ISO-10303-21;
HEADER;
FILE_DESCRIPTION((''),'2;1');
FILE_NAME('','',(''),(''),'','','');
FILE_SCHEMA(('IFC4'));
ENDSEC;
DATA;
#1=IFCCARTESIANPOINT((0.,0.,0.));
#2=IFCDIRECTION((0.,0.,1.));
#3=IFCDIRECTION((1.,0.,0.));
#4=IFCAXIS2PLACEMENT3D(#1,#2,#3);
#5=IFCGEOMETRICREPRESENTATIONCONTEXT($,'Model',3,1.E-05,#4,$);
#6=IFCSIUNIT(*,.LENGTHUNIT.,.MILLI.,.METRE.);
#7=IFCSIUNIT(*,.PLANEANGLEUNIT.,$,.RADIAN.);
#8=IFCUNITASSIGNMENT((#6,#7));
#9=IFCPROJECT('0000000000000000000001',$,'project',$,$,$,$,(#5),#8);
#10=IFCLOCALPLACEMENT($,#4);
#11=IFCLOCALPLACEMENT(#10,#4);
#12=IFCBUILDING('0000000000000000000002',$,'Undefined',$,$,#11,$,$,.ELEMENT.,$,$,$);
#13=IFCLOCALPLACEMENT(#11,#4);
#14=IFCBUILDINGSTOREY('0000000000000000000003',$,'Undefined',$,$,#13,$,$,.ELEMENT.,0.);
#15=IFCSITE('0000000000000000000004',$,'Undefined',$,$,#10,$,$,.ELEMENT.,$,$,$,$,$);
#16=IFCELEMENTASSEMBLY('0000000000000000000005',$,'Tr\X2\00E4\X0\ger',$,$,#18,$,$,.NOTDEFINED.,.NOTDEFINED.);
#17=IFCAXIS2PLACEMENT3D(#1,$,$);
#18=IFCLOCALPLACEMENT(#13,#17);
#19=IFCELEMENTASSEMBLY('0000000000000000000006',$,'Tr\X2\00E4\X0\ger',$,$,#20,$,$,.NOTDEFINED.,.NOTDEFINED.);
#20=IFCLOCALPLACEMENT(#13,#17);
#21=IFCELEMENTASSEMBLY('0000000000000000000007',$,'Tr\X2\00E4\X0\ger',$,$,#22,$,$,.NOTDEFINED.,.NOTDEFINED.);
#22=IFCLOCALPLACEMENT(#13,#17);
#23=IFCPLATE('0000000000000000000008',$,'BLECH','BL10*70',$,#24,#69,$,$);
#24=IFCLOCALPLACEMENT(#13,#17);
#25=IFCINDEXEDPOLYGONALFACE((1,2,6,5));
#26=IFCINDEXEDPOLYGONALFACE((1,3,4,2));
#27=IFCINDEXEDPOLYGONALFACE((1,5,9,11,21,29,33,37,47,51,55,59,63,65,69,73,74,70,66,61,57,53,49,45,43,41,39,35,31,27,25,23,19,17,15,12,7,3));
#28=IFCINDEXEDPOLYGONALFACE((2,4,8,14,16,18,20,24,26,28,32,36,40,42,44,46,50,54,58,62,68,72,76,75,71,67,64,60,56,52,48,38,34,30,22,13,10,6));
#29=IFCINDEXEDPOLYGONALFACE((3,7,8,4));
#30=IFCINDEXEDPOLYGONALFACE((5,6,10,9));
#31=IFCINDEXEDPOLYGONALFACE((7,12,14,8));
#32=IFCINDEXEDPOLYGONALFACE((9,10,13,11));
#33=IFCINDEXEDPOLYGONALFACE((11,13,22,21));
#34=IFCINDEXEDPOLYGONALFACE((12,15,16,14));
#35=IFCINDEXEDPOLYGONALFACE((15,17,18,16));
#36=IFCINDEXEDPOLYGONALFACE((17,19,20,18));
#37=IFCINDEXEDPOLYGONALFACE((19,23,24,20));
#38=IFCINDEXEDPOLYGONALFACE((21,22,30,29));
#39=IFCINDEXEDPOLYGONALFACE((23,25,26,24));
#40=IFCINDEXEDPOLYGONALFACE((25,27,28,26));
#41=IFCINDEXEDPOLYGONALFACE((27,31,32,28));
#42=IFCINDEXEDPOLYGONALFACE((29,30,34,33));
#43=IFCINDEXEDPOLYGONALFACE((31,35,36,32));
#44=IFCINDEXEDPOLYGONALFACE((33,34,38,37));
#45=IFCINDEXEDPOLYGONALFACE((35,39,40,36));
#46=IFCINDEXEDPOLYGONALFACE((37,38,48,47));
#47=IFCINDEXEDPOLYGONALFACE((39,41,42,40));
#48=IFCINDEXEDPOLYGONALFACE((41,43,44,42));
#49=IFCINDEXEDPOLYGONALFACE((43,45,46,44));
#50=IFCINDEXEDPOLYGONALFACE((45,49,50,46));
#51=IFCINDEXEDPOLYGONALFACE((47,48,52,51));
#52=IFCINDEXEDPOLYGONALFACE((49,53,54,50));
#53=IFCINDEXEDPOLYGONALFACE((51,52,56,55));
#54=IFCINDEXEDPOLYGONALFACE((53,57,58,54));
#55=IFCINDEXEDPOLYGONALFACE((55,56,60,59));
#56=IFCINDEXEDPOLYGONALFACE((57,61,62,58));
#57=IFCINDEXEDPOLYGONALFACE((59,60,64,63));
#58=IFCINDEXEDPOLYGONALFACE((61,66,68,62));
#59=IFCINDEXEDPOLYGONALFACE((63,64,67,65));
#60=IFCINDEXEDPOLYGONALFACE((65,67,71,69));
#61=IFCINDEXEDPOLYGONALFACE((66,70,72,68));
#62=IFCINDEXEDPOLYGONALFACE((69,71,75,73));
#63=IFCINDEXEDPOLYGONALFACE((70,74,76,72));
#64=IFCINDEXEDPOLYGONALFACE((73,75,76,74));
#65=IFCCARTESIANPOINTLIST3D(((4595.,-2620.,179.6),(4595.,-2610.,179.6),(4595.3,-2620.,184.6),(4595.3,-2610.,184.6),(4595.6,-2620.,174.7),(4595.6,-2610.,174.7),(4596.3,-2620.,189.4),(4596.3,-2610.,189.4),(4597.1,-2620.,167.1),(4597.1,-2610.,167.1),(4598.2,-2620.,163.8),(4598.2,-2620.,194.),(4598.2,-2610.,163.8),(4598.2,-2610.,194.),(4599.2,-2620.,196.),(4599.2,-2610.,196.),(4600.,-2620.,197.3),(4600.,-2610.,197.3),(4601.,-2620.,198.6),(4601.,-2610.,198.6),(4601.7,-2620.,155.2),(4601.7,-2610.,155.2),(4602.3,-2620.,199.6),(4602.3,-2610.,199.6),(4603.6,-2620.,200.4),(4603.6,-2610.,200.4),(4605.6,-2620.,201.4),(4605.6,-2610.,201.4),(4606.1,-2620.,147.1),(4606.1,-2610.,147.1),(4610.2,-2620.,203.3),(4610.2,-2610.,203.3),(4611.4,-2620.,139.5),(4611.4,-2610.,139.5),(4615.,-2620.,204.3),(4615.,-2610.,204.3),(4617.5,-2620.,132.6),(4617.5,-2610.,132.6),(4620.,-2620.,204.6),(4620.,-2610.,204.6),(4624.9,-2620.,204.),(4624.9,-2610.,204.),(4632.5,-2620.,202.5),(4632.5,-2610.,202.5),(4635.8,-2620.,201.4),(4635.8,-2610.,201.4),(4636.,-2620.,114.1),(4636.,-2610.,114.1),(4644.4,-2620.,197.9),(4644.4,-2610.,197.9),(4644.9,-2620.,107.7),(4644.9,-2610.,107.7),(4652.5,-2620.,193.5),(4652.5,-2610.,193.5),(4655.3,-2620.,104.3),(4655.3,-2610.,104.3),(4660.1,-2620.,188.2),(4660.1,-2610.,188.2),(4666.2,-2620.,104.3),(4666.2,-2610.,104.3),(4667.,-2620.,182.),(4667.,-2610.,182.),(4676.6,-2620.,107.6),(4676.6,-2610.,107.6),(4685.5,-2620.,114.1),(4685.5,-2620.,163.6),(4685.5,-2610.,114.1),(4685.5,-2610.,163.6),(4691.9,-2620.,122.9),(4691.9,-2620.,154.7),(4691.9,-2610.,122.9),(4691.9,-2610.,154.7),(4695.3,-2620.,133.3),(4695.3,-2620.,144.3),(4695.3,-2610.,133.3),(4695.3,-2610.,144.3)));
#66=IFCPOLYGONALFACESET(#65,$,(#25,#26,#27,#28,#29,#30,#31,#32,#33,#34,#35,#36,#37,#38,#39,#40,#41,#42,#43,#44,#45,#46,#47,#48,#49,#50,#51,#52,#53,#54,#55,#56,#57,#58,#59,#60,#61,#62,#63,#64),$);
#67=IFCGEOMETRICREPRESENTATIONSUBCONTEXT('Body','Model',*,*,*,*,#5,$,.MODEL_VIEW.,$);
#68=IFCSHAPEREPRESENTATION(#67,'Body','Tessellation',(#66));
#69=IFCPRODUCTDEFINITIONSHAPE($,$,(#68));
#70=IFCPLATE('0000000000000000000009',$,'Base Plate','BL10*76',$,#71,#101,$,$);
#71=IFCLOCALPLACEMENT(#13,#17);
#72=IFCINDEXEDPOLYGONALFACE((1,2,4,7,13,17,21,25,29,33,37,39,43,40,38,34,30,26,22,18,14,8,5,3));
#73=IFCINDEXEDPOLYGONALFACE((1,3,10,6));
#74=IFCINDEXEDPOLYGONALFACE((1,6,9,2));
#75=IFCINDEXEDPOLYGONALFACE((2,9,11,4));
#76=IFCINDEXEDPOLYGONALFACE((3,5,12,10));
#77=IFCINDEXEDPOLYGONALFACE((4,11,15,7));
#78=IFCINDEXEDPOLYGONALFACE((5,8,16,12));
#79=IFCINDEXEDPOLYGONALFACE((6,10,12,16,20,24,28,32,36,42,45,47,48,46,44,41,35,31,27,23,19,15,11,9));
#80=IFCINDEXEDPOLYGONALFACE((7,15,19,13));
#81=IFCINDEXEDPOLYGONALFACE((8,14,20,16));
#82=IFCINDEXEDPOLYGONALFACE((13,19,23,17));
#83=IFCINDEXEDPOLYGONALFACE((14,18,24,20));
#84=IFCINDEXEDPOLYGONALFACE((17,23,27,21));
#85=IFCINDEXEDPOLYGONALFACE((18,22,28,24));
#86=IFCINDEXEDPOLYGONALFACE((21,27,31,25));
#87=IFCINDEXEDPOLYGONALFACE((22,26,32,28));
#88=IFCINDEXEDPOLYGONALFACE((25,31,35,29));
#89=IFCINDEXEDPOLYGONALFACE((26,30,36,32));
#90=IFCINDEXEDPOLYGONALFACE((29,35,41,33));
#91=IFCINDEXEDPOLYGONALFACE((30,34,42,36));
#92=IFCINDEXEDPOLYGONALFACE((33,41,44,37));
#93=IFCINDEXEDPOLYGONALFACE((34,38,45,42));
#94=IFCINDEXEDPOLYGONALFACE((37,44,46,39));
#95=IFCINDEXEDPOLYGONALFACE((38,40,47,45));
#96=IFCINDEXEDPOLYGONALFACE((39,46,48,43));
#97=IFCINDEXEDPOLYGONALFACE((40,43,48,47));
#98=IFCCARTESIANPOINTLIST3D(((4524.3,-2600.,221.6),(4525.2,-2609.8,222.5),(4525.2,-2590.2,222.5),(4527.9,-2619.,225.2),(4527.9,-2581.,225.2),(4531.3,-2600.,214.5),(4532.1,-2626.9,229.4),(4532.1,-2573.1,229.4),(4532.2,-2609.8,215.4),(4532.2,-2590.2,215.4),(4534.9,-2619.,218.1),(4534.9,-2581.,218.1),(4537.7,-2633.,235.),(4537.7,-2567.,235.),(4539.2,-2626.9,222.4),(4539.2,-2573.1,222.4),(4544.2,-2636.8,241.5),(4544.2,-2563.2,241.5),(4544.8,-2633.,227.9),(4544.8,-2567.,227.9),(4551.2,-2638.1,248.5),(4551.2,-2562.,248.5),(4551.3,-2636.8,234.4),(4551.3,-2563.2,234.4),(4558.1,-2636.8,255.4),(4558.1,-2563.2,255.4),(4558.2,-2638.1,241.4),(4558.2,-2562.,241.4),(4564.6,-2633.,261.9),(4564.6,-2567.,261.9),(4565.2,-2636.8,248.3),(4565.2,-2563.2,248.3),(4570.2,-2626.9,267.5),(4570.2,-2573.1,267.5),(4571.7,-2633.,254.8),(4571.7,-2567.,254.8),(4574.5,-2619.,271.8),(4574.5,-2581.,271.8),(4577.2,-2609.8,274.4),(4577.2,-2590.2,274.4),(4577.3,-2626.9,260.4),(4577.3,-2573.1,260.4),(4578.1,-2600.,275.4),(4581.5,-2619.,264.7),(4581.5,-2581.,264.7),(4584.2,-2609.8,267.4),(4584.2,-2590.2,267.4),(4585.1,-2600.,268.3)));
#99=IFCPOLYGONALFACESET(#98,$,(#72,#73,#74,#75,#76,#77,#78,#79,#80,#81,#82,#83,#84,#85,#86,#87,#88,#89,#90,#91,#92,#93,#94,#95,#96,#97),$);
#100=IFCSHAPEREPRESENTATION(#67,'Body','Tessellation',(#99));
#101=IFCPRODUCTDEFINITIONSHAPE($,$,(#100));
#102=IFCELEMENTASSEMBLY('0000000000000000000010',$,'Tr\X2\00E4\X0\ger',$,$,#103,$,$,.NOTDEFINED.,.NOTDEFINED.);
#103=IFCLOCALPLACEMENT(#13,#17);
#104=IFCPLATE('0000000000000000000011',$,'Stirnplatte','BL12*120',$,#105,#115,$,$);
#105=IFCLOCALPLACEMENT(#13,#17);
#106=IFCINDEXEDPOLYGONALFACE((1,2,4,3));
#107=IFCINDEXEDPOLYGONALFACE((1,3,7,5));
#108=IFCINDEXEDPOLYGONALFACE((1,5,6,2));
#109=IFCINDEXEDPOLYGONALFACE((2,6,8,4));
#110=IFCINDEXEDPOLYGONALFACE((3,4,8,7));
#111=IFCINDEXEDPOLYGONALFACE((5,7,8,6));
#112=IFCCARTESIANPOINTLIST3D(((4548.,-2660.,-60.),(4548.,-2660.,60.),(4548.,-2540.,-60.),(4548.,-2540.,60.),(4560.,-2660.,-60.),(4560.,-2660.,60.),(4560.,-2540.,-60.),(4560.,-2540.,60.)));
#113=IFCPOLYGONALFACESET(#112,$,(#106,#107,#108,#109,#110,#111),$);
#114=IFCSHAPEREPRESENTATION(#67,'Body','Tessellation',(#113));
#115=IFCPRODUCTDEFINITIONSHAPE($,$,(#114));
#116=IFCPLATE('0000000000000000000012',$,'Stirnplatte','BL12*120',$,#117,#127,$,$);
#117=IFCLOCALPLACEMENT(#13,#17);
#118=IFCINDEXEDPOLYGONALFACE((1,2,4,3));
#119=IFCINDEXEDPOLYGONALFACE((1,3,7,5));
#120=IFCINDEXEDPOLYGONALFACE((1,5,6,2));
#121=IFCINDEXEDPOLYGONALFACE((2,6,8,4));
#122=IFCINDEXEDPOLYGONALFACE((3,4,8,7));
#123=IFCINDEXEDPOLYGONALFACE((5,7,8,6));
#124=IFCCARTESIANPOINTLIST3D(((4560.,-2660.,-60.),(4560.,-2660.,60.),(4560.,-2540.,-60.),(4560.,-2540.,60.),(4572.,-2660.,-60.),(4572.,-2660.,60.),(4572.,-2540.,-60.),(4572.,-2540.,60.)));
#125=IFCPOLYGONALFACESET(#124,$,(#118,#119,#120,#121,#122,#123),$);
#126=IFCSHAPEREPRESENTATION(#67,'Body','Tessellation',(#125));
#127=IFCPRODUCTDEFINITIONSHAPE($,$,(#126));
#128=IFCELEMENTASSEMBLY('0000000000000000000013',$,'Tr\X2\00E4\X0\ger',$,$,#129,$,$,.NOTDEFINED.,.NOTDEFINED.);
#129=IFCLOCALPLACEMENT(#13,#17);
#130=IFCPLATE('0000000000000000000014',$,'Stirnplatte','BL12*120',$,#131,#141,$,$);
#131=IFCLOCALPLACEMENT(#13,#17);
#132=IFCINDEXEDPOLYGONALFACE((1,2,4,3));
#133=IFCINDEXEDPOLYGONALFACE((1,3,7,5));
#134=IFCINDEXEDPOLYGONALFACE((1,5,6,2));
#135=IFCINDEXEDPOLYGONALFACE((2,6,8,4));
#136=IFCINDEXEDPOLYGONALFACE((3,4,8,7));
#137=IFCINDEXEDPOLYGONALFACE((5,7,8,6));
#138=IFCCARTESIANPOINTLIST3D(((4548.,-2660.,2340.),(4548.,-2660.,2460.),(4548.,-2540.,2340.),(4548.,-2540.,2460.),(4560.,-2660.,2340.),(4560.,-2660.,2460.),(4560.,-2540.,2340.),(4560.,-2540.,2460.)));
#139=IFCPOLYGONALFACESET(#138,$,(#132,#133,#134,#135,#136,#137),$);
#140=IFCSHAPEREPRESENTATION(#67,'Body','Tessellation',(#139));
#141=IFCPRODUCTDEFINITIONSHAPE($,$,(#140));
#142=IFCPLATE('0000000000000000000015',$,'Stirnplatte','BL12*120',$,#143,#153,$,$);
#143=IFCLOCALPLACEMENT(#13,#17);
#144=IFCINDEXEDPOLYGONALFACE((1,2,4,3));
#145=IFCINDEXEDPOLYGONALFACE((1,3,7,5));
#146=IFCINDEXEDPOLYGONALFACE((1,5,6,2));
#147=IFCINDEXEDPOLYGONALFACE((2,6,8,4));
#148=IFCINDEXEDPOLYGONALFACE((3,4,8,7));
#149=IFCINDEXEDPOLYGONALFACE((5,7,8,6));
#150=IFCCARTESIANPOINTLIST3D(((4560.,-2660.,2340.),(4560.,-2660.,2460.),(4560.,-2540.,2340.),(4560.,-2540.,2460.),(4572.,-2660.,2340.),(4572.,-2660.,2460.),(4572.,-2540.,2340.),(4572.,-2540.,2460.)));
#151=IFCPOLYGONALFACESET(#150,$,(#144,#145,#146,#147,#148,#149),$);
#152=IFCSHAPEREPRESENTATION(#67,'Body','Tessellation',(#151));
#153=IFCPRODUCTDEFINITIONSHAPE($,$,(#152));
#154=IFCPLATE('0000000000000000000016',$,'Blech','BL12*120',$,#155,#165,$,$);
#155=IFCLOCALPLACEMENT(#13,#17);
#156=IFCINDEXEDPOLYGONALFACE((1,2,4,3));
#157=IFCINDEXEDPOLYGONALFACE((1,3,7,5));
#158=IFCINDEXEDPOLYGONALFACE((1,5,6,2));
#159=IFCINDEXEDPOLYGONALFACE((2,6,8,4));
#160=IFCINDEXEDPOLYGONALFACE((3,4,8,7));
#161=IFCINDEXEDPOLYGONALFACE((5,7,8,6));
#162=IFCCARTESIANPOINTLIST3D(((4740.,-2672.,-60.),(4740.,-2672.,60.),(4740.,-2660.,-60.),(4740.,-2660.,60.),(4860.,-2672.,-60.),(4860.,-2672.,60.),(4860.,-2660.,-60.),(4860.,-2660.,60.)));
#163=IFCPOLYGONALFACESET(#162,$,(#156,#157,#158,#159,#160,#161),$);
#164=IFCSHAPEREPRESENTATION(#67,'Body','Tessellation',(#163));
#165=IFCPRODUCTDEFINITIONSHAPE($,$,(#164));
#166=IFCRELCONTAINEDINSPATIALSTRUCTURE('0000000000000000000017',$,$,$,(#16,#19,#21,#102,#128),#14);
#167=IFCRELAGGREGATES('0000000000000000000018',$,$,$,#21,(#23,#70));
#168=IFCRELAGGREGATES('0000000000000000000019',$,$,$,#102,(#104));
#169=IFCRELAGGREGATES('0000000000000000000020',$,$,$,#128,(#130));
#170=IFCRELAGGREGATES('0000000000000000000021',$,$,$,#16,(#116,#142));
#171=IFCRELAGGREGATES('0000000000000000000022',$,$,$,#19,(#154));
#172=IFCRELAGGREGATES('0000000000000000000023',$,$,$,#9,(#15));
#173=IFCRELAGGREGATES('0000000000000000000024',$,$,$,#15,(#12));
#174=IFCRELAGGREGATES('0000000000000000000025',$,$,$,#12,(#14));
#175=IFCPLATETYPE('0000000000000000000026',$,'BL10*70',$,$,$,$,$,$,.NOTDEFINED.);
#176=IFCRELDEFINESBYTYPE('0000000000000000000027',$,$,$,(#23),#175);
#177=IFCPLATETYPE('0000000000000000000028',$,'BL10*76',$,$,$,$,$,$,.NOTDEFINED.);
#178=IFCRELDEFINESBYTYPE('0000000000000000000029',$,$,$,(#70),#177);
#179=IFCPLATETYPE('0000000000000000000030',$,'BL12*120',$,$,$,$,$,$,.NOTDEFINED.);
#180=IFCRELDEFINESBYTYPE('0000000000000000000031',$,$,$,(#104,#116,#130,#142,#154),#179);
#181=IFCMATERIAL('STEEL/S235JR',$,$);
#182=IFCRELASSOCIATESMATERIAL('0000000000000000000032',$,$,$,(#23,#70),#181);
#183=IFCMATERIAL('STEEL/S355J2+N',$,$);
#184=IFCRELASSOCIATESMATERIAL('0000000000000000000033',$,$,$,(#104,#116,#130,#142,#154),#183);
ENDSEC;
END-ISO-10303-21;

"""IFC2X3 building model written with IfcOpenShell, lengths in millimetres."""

from ifc_helpers import new_model, si_unit, frame, frame_2d, origin_with_axes, place, context, subcontext, project, spatial, polyline, circle_curve, parameter, trimmed, segment, composite_curve, outline, extrude, material, type_object, element, aggregate, save


model = new_model("IFC2X3")

# Units and contexts
model_context = context("Model", 3, precision=1e-05, world=origin_with_axes())
body_context = subcontext(model_context, "Body", "Model", "MODEL_VIEW")
ifc_project = project(units=[si_unit("LENGTHUNIT", "METRE", prefix="MILLI"), si_unit("PLANEANGLEUNIT", "RADIAN")], contexts=[model_context])

# Site, building, storey
site_placement = place(None, origin_with_axes())
site = spatial("IfcSite", under=ifc_project, at=site_placement, Name="Undefined", CompositionType="ELEMENT")
building_placement = place(site_placement, origin_with_axes())
building = spatial("IfcBuilding", under=site, at=building_placement, Name="Undefined", CompositionType="ELEMENT")
storey_placement = place(building_placement, origin_with_axes())
storey = spatial("IfcBuildingStorey", under=building, at=storey_placement, Name="Undefined", CompositionType="ELEMENT", Elevation=0.0)

# Shared definitions
ifc_material_1 = material(Name="STEEL/S235JR")

# Element assemblies
assembly_1_placement = place(storey_placement, origin_with_axes())
assembly_1 = element("IfcElementAssembly", 1, at=assembly_1_placement, inside=storey, Name="Träger", AssemblyPlace="NOTDEFINED", PredefinedType="NOTDEFINED")
assembly_2_placement = place(storey_placement, origin_with_axes())
assembly_2 = element("IfcElementAssembly", 2, at=assembly_2_placement, inside=storey, Name="Träger", AssemblyPlace="NOTDEFINED", PredefinedType="NOTDEFINED")

# Shared definitions
plate_type_1 = type_object("IfcPlateType", Name="BL10*70", PredefinedType="NOTDEFINED")

# Element assembly, plate
assembly_3_placement = place(storey_placement, origin_with_axes())
assembly_3 = element("IfcElementAssembly", 3, at=assembly_3_placement, inside=storey, Name="Träger", AssemblyPlace="NOTDEFINED", PredefinedType="NOTDEFINED")
plate_1_placement = place(assembly_3_placement, frame((4604.2, -2615.0, 145.9), z_axis=(0.0, 1.0, 0.0), x_axis=(-0.316089, 0.0, 0.94873)))
plate_1 = element("IfcPlate", 4, at=plate_1_placement, type_object=plate_type_1, material=ifc_material_1, Name="BLECH", Description="BL10*70", context=body_context, shape_type="SweptSolid", body=[
    extrude(outline(polyline([(-16.9, 8.4), (-8.4, 4.8), (0.5, 2.1), (9.6, 0.5), (18.9, 0.0), (22.4, 0.0), (30.0, 1.0), (34.9, 2.0), (39.5, 3.8), (43.7, 6.3), (47.5, 9.5), (49.1, 11.1), (50.1, 12.3), (50.9, 13.7), (51.5, 15.1), (51.9, 16.7), (52.2, 18.9), (52.5, 23.8), (52.0, 28.7), (50.6, 33.5), (48.6, 38.0), (44.7, 44.7), (42.6, 47.5), (36.6, 54.6), (29.9, 60.9), (22.4, 66.4), (14.4, 71.0), (-9.0, 82.7), (-19.4, 86.0), (-30.3, 86.0), (-40.7, 82.5), (-49.5, 76.0), (-55.9, 67.1), (-55.9, 67.1), (-59.2, 56.6), (-59.1, 45.7), (-55.7, 35.3), (-49.2, 26.5), (-40.3, 20.1), (-16.9, 8.4)])), frame((0.0, 0.0, -5.0), z_axis=(0.0, 0.0, 1.0), x_axis=(1.0, 0.0, 0.0)), (0.0, 0.0, 1.0), 10.0),
])

# Plate
plate_type_2 = type_object("IfcPlateType", Name="BL10*76", PredefinedType="NOTDEFINED")
plate_2_placement = place(assembly_3_placement, frame((4581.6, -2638.1, 271.8), z_axis=(0.707003, 0.0, -0.70721), x_axis=(-0.70721, 0.0, -0.707003)))
plate_2 = element("IfcPlate", 5, at=plate_2_placement, type_object=plate_type_2, material=ifc_material_1, Name="Base Plate", Description="BL10*76", context=body_context, shape_type="SweptSolid", body=[
    extrude(outline(composite_curve([segment(trimmed(circle_curve(frame_2d((38.0, 38.0), x_axis=(-1.0, 0.0)), 38.0), [parameter(0.0)], [parameter(1.570796)], True, "PARAMETER"), True, "CONTINUOUS"), segment(trimmed(circle_curve(frame_2d((38.0, 38.0), x_axis=(0.0, -1.0)), 38.0), [parameter(0.0)], [parameter(1.570796)], True, "PARAMETER"), True, "CONTINUOUS"), segment(trimmed(circle_curve(frame_2d((38.0, 38.0), x_axis=(1.0, 0.0)), 38.0), [parameter(0.0)], [parameter(1.570796)], True, "PARAMETER"), True, "CONTINUOUS"), segment(trimmed(circle_curve(frame_2d((38.0, 38.0), x_axis=(0.0, 1.0)), 38.0), [parameter(0.0)], [parameter(1.570796)], True, "PARAMETER"), True, "CONTINUOUS")], self_intersect=True)), frame((0.0, 0.0, -5.0), z_axis=(0.0, 0.0, 1.0), x_axis=(1.0, 0.0, 0.0)), (0.0, 0.0, 1.0), 10.0),
])
aggregate(assembly_3, [plate_1, plate_2])

# Element assembly, plate
assembly_4_placement = place(storey_placement, origin_with_axes())
assembly_4 = element("IfcElementAssembly", 6, at=assembly_4_placement, inside=storey, Name="Träger", AssemblyPlace="NOTDEFINED", PredefinedType="NOTDEFINED")
ifc_material_2 = material(Name="STEEL/S355J2+N")
plate_type_3 = type_object("IfcPlateType", Name="BL12*120", PredefinedType="NOTDEFINED")
plate_3_placement = place(assembly_4_placement, frame((4554.0, -2600.0, -60.0), z_axis=(-1.0, 0.0, 0.0), x_axis=(0.0, 0.0, 1.0)))
plate_3 = element("IfcPlate", 7, at=plate_3_placement, type_object=plate_type_3, material=ifc_material_2, Name="Stirnplatte", Description="BL12*120", context=body_context, shape_type="SweptSolid", body=[
    extrude(outline(polyline([(0.0, -60.0), (0.0, 60.0), (120.0, 60.0), (120.0, -60.0), (0.0, -60.0)])), frame((0.0, 0.0, -6.0), z_axis=(0.0, 0.0, 1.0), x_axis=(1.0, 0.0, 0.0)), (0.0, 0.0, 1.0), 12.0),
])
aggregate(assembly_4, [plate_3])

# Plate
plate_4_placement = place(assembly_1_placement, frame((4566.0, -2600.0, -60.0), z_axis=(-1.0, 0.0, 0.0), x_axis=(0.0, 0.0, 1.0)))
plate_4 = element("IfcPlate", 8, at=plate_4_placement, type_object=plate_type_3, material=ifc_material_2, Name="Stirnplatte", Description="BL12*120", context=body_context, shape_type="SweptSolid", body=[
    extrude(outline(polyline([(0.0, -60.0), (0.0, 60.0), (120.0, 60.0), (120.0, -60.0), (0.0, -60.0)])), frame((0.0, 0.0, -6.0), z_axis=(0.0, 0.0, 1.0), x_axis=(1.0, 0.0, 0.0)), (0.0, 0.0, 1.0), 12.0),
])

# Element assembly, plate
assembly_5_placement = place(storey_placement, origin_with_axes())
assembly_5 = element("IfcElementAssembly", 9, at=assembly_5_placement, inside=storey, Name="Träger", AssemblyPlace="NOTDEFINED", PredefinedType="NOTDEFINED")
plate_5_placement = place(assembly_5_placement, frame((4554.0, -2600.0, 2340.0), z_axis=(-1.0, 0.0, 0.0), x_axis=(0.0, 0.0, 1.0)))
plate_5 = element("IfcPlate", 10, at=plate_5_placement, type_object=plate_type_3, material=ifc_material_2, Name="Stirnplatte", Description="BL12*120", context=body_context, shape_type="SweptSolid", body=[
    extrude(outline(polyline([(0.0, -60.0), (0.0, 60.0), (120.0, 60.0), (120.0, -60.0), (0.0, -60.0)])), frame((0.0, 0.0, -6.0), z_axis=(0.0, 0.0, 1.0), x_axis=(1.0, 0.0, 0.0)), (0.0, 0.0, 1.0), 12.0),
])
aggregate(assembly_5, [plate_5])

# Plates
plate_6_placement = place(assembly_1_placement, frame((4566.0, -2600.0, 2340.0), z_axis=(-1.0, 0.0, 0.0), x_axis=(0.0, 0.0, 1.0)))
plate_6 = element("IfcPlate", 11, at=plate_6_placement, type_object=plate_type_3, material=ifc_material_2, Name="Stirnplatte", Description="BL12*120", context=body_context, shape_type="SweptSolid", body=[
    extrude(outline(polyline([(0.0, -60.0), (0.0, 60.0), (120.0, 60.0), (120.0, -60.0), (0.0, -60.0)])), frame((0.0, 0.0, -6.0), z_axis=(0.0, 0.0, 1.0), x_axis=(1.0, 0.0, 0.0)), (0.0, 0.0, 1.0), 12.0),
])
aggregate(assembly_1, [plate_4, plate_6])
plate_7_placement = place(assembly_2_placement, frame((4800.0, -2666.0, -60.0), z_axis=(0.0, -1.0, 0.0), x_axis=(0.0, 0.0, 1.0)))
plate_7 = element("IfcPlate", 12, at=plate_7_placement, type_object=plate_type_3, material=ifc_material_2, Name="Blech", Description="BL12*120", context=body_context, shape_type="SweptSolid", body=[
    extrude(outline(polyline([(0.0, -60.0), (0.0, 60.0), (120.0, 60.0), (120.0, -60.0), (0.0, -60.0)])), frame((0.0, 0.0, -6.0), z_axis=(0.0, 0.0, 1.0), x_axis=(1.0, 0.0, 0.0)), (0.0, 0.0, 1.0), 12.0),
])
aggregate(assembly_2, [plate_7])

save(model, "model.ifc")
